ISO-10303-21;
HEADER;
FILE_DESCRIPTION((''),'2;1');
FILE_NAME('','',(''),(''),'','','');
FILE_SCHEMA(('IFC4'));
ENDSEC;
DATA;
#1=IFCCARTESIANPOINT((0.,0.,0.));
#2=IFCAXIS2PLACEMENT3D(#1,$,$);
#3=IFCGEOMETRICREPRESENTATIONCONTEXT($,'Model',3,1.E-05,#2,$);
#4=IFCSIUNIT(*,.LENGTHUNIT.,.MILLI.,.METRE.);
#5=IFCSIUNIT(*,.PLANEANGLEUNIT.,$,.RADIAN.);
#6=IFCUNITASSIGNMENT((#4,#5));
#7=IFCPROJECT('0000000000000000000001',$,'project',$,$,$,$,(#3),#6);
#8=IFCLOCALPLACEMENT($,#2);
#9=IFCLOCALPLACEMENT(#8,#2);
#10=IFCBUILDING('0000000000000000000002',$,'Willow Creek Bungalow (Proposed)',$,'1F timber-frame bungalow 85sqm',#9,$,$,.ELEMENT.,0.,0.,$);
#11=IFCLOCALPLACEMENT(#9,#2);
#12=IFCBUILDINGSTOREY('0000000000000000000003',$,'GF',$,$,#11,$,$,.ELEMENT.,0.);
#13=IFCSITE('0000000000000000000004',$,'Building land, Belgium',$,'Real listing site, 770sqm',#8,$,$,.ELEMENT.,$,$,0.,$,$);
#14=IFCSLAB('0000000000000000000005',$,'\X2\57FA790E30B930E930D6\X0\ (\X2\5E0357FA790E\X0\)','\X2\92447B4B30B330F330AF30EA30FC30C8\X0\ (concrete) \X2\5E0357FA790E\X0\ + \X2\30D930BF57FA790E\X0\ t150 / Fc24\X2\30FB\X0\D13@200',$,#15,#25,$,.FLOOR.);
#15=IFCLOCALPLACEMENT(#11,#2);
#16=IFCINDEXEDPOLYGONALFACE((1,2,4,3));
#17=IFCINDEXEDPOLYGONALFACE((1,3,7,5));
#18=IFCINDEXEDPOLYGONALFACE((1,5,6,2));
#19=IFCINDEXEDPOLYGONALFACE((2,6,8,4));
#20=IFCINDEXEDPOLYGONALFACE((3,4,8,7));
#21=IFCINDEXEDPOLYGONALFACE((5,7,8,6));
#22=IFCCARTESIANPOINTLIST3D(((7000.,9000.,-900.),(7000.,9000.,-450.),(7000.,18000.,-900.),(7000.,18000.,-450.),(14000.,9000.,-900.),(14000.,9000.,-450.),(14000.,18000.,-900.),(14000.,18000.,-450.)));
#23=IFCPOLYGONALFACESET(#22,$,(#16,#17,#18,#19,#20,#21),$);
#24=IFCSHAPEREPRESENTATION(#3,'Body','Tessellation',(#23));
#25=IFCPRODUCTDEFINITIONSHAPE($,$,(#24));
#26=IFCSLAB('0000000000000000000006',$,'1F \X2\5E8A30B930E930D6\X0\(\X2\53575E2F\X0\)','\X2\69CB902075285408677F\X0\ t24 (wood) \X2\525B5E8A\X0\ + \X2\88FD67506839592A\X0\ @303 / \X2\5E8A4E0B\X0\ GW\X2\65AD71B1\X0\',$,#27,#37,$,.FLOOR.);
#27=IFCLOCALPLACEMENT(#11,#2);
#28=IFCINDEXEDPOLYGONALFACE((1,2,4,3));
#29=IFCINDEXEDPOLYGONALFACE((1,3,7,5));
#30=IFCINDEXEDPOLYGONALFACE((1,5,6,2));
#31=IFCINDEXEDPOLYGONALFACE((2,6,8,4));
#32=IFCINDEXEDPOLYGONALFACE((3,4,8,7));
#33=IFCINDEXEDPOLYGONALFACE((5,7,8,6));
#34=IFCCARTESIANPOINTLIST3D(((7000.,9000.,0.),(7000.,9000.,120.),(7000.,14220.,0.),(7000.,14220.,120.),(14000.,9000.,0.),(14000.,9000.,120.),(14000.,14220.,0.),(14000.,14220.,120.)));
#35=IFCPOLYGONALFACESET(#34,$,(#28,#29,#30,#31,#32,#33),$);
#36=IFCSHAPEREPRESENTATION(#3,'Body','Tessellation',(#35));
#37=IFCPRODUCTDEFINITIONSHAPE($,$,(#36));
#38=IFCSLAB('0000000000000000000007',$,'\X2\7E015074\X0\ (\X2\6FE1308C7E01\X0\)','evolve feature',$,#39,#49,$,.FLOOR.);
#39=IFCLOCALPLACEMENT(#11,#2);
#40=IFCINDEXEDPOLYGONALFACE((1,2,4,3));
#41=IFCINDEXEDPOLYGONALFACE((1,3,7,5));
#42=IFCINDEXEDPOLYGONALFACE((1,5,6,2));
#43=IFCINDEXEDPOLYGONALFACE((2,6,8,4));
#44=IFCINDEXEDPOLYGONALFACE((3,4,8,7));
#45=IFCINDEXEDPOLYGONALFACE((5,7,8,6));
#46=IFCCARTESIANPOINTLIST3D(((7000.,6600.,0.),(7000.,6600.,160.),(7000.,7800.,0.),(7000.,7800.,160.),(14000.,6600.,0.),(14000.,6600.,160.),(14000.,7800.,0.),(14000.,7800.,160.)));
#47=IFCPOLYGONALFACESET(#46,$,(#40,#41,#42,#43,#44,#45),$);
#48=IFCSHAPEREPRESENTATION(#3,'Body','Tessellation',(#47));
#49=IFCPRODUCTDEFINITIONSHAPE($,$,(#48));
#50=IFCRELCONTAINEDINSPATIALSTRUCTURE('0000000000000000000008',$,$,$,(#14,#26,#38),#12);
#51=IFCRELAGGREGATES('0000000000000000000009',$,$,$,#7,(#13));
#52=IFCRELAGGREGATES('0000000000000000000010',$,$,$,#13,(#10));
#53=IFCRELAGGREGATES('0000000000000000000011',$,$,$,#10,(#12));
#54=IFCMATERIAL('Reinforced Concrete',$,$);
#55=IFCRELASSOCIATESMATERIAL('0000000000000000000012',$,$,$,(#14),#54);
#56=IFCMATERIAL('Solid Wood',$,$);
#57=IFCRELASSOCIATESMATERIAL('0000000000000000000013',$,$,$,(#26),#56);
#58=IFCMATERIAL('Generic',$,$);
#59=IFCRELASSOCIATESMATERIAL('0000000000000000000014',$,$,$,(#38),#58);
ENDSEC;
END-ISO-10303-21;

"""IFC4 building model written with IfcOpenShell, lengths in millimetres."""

from ifc_helpers import new_model, si_unit, frame, frame_2d, origin, place, context, project, spatial, rectangle, extrude, material, element, save


model = new_model("IFC4")

# Units and contexts
model_context = context("Model", 3, precision=1e-05, world=origin())
ifc_project = project(units=[si_unit("LENGTHUNIT", "METRE", prefix="MILLI"), si_unit("PLANEANGLEUNIT", "RADIAN")], contexts=[model_context])

# Site, building, storey
site_placement = place(None, origin())
site = spatial("IfcSite", under=ifc_project, at=site_placement, Name="Building land, Belgium", ObjectType="Real listing site, 770sqm", CompositionType="ELEMENT", RefElevation=0.0)
building_placement = place(site_placement, origin())
building = spatial("IfcBuilding", under=site, at=building_placement, Name="Willow Creek Bungalow (Proposed)", ObjectType="1F timber-frame bungalow 85sqm", CompositionType="ELEMENT", ElevationOfRefHeight=0.0, ElevationOfTerrain=0.0)
storey_placement = place(building_placement, origin())
storey = spatial("IfcBuildingStorey", under=building, at=storey_placement, Name="GF", CompositionType="ELEMENT", Elevation=0.0)

# Slabs
ifc_material_1 = material(Name="Reinforced Concrete")
slab_1_placement = place(storey_placement, frame((3500.0, 4500.0, -450.0)))
element("IfcSlab", 1, at=slab_1_placement, inside=storey, material=ifc_material_1, Name="基礎スラブ (布基礎)", Description="鉄筋コンクリート (concrete) 布基礎 + ベタ基礎 t150 / Fc24・D13@200", PredefinedType="FLOOR", context=model_context, shape_type="SweptSolid", body=[
    extrude(rectangle(XDim=7000.0, YDim=9000.0, at=frame_2d((3500.0, 4500.0))), frame((3500.0, 4500.0, -450.0)), (0.0, 0.0, 1.0), 450.0),
])
ifc_material_2 = material(Name="Solid Wood")
slab_2_placement = place(storey_placement, frame((3500.0, 4500.0, 0.0)))
element("IfcSlab", 2, at=slab_2_placement, inside=storey, material=ifc_material_2, Name="1F 床スラブ(南帯)", Description="構造用合板 t24 (wood) 剛床 + 製材根太 @303 / 床下 GW断熱", PredefinedType="FLOOR", context=model_context, shape_type="SweptSolid", body=[
    extrude(rectangle(XDim=7000.0, YDim=5220.0, at=frame_2d((3500.0, 2610.0))), frame((3500.0, 4500.0, 0.0)), (0.0, 0.0, 1.0), 120.0),
])
ifc_material_3 = material(Name="Generic")
slab_3_placement = place(storey_placement, frame((3500.0, 3300.0, 0.0)))
element("IfcSlab", 3, at=slab_3_placement, inside=storey, material=ifc_material_3, Name="縁側 (濡れ縁)", Description="evolve feature", PredefinedType="FLOOR", context=model_context, shape_type="SweptSolid", body=[
    extrude(rectangle(XDim=7000.0, YDim=1200.0, at=frame_2d((3500.0, 600.0))), frame((3500.0, 3300.0, 0.0)), (0.0, 0.0, 1.0), 160.0),
])

save(model, "model.ifc")
